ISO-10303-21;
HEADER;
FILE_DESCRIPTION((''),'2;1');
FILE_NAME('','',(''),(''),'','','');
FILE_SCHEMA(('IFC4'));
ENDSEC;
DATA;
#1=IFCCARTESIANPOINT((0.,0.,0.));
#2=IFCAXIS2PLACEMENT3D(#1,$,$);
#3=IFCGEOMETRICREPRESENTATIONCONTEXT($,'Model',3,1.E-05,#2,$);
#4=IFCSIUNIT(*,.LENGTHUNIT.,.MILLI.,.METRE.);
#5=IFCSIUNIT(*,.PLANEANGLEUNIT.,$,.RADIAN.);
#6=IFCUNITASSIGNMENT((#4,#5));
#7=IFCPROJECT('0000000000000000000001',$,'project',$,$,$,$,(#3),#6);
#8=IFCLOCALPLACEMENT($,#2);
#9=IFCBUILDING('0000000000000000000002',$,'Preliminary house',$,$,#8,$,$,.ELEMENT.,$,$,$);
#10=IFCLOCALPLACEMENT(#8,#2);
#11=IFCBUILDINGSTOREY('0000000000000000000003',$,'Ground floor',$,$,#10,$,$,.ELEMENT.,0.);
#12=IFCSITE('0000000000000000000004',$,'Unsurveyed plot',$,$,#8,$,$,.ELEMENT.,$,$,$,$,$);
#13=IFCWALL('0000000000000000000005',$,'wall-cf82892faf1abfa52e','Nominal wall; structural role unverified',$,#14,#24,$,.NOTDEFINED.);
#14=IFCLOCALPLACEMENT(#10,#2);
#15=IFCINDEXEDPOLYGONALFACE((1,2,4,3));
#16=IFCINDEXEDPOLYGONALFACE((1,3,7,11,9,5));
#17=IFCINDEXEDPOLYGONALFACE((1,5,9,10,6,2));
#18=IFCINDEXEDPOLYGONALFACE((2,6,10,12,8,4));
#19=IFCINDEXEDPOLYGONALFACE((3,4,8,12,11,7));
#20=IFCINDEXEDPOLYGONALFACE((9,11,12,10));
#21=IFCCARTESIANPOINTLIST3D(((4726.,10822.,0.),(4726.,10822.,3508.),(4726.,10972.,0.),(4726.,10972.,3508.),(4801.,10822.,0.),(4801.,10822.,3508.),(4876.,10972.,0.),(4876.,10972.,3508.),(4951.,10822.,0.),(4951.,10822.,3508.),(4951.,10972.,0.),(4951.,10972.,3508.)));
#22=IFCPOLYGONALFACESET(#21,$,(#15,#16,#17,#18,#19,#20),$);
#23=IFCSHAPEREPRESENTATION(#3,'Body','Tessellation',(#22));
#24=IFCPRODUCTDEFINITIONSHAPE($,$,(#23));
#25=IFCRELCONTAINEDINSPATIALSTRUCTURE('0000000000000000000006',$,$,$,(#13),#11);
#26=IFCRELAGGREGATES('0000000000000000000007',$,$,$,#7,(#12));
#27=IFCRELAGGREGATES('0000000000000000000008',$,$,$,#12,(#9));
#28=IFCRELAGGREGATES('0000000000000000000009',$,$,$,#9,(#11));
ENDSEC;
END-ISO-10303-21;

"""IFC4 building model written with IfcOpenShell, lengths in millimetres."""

from ifc_helpers import new_model, si_unit, origin, place, context, project, spatial, polyline, outline, extrude, element, save


model = new_model("IFC4")

# Units and contexts
model_context = context("Model", 3, precision=1e-05, world=origin())
ifc_project = project(units=[si_unit("LENGTHUNIT", "METRE", prefix="MILLI"), si_unit("PLANEANGLEUNIT", "RADIAN")], contexts=[model_context])

# Site, building, storey
placement_1 = place(None, origin())
site = spatial("IfcSite", under=ifc_project, at=placement_1, Name="Unsurveyed plot", CompositionType="ELEMENT")
building = spatial("IfcBuilding", under=site, at=placement_1, Name="Preliminary house", CompositionType="ELEMENT")
placement_2 = place(placement_1, origin())
storey = spatial("IfcBuildingStorey", under=building, at=placement_2, Name="Ground floor", CompositionType="ELEMENT", Elevation=0.0)

# Wall
element("IfcWall", 1, at=placement_2, inside=storey, Name="wall-cf82892faf1abfa52e", Description="Nominal wall; structural role unverified", PredefinedType="NOTDEFINED", context=model_context, shape_type="SweptSolid", body=[
    extrude(outline(polyline([(4876.0, 10972.0), (4951.0, 10972.0), (4951.0, 10822.0), (4801.0, 10822.0), (4726.0, 10822.0), (4726.0, 10972.0), (4876.0, 10972.0)])), origin(), (0.0, 0.0, 1.0), 3508.0),
])

save(model, "model.ifc")
